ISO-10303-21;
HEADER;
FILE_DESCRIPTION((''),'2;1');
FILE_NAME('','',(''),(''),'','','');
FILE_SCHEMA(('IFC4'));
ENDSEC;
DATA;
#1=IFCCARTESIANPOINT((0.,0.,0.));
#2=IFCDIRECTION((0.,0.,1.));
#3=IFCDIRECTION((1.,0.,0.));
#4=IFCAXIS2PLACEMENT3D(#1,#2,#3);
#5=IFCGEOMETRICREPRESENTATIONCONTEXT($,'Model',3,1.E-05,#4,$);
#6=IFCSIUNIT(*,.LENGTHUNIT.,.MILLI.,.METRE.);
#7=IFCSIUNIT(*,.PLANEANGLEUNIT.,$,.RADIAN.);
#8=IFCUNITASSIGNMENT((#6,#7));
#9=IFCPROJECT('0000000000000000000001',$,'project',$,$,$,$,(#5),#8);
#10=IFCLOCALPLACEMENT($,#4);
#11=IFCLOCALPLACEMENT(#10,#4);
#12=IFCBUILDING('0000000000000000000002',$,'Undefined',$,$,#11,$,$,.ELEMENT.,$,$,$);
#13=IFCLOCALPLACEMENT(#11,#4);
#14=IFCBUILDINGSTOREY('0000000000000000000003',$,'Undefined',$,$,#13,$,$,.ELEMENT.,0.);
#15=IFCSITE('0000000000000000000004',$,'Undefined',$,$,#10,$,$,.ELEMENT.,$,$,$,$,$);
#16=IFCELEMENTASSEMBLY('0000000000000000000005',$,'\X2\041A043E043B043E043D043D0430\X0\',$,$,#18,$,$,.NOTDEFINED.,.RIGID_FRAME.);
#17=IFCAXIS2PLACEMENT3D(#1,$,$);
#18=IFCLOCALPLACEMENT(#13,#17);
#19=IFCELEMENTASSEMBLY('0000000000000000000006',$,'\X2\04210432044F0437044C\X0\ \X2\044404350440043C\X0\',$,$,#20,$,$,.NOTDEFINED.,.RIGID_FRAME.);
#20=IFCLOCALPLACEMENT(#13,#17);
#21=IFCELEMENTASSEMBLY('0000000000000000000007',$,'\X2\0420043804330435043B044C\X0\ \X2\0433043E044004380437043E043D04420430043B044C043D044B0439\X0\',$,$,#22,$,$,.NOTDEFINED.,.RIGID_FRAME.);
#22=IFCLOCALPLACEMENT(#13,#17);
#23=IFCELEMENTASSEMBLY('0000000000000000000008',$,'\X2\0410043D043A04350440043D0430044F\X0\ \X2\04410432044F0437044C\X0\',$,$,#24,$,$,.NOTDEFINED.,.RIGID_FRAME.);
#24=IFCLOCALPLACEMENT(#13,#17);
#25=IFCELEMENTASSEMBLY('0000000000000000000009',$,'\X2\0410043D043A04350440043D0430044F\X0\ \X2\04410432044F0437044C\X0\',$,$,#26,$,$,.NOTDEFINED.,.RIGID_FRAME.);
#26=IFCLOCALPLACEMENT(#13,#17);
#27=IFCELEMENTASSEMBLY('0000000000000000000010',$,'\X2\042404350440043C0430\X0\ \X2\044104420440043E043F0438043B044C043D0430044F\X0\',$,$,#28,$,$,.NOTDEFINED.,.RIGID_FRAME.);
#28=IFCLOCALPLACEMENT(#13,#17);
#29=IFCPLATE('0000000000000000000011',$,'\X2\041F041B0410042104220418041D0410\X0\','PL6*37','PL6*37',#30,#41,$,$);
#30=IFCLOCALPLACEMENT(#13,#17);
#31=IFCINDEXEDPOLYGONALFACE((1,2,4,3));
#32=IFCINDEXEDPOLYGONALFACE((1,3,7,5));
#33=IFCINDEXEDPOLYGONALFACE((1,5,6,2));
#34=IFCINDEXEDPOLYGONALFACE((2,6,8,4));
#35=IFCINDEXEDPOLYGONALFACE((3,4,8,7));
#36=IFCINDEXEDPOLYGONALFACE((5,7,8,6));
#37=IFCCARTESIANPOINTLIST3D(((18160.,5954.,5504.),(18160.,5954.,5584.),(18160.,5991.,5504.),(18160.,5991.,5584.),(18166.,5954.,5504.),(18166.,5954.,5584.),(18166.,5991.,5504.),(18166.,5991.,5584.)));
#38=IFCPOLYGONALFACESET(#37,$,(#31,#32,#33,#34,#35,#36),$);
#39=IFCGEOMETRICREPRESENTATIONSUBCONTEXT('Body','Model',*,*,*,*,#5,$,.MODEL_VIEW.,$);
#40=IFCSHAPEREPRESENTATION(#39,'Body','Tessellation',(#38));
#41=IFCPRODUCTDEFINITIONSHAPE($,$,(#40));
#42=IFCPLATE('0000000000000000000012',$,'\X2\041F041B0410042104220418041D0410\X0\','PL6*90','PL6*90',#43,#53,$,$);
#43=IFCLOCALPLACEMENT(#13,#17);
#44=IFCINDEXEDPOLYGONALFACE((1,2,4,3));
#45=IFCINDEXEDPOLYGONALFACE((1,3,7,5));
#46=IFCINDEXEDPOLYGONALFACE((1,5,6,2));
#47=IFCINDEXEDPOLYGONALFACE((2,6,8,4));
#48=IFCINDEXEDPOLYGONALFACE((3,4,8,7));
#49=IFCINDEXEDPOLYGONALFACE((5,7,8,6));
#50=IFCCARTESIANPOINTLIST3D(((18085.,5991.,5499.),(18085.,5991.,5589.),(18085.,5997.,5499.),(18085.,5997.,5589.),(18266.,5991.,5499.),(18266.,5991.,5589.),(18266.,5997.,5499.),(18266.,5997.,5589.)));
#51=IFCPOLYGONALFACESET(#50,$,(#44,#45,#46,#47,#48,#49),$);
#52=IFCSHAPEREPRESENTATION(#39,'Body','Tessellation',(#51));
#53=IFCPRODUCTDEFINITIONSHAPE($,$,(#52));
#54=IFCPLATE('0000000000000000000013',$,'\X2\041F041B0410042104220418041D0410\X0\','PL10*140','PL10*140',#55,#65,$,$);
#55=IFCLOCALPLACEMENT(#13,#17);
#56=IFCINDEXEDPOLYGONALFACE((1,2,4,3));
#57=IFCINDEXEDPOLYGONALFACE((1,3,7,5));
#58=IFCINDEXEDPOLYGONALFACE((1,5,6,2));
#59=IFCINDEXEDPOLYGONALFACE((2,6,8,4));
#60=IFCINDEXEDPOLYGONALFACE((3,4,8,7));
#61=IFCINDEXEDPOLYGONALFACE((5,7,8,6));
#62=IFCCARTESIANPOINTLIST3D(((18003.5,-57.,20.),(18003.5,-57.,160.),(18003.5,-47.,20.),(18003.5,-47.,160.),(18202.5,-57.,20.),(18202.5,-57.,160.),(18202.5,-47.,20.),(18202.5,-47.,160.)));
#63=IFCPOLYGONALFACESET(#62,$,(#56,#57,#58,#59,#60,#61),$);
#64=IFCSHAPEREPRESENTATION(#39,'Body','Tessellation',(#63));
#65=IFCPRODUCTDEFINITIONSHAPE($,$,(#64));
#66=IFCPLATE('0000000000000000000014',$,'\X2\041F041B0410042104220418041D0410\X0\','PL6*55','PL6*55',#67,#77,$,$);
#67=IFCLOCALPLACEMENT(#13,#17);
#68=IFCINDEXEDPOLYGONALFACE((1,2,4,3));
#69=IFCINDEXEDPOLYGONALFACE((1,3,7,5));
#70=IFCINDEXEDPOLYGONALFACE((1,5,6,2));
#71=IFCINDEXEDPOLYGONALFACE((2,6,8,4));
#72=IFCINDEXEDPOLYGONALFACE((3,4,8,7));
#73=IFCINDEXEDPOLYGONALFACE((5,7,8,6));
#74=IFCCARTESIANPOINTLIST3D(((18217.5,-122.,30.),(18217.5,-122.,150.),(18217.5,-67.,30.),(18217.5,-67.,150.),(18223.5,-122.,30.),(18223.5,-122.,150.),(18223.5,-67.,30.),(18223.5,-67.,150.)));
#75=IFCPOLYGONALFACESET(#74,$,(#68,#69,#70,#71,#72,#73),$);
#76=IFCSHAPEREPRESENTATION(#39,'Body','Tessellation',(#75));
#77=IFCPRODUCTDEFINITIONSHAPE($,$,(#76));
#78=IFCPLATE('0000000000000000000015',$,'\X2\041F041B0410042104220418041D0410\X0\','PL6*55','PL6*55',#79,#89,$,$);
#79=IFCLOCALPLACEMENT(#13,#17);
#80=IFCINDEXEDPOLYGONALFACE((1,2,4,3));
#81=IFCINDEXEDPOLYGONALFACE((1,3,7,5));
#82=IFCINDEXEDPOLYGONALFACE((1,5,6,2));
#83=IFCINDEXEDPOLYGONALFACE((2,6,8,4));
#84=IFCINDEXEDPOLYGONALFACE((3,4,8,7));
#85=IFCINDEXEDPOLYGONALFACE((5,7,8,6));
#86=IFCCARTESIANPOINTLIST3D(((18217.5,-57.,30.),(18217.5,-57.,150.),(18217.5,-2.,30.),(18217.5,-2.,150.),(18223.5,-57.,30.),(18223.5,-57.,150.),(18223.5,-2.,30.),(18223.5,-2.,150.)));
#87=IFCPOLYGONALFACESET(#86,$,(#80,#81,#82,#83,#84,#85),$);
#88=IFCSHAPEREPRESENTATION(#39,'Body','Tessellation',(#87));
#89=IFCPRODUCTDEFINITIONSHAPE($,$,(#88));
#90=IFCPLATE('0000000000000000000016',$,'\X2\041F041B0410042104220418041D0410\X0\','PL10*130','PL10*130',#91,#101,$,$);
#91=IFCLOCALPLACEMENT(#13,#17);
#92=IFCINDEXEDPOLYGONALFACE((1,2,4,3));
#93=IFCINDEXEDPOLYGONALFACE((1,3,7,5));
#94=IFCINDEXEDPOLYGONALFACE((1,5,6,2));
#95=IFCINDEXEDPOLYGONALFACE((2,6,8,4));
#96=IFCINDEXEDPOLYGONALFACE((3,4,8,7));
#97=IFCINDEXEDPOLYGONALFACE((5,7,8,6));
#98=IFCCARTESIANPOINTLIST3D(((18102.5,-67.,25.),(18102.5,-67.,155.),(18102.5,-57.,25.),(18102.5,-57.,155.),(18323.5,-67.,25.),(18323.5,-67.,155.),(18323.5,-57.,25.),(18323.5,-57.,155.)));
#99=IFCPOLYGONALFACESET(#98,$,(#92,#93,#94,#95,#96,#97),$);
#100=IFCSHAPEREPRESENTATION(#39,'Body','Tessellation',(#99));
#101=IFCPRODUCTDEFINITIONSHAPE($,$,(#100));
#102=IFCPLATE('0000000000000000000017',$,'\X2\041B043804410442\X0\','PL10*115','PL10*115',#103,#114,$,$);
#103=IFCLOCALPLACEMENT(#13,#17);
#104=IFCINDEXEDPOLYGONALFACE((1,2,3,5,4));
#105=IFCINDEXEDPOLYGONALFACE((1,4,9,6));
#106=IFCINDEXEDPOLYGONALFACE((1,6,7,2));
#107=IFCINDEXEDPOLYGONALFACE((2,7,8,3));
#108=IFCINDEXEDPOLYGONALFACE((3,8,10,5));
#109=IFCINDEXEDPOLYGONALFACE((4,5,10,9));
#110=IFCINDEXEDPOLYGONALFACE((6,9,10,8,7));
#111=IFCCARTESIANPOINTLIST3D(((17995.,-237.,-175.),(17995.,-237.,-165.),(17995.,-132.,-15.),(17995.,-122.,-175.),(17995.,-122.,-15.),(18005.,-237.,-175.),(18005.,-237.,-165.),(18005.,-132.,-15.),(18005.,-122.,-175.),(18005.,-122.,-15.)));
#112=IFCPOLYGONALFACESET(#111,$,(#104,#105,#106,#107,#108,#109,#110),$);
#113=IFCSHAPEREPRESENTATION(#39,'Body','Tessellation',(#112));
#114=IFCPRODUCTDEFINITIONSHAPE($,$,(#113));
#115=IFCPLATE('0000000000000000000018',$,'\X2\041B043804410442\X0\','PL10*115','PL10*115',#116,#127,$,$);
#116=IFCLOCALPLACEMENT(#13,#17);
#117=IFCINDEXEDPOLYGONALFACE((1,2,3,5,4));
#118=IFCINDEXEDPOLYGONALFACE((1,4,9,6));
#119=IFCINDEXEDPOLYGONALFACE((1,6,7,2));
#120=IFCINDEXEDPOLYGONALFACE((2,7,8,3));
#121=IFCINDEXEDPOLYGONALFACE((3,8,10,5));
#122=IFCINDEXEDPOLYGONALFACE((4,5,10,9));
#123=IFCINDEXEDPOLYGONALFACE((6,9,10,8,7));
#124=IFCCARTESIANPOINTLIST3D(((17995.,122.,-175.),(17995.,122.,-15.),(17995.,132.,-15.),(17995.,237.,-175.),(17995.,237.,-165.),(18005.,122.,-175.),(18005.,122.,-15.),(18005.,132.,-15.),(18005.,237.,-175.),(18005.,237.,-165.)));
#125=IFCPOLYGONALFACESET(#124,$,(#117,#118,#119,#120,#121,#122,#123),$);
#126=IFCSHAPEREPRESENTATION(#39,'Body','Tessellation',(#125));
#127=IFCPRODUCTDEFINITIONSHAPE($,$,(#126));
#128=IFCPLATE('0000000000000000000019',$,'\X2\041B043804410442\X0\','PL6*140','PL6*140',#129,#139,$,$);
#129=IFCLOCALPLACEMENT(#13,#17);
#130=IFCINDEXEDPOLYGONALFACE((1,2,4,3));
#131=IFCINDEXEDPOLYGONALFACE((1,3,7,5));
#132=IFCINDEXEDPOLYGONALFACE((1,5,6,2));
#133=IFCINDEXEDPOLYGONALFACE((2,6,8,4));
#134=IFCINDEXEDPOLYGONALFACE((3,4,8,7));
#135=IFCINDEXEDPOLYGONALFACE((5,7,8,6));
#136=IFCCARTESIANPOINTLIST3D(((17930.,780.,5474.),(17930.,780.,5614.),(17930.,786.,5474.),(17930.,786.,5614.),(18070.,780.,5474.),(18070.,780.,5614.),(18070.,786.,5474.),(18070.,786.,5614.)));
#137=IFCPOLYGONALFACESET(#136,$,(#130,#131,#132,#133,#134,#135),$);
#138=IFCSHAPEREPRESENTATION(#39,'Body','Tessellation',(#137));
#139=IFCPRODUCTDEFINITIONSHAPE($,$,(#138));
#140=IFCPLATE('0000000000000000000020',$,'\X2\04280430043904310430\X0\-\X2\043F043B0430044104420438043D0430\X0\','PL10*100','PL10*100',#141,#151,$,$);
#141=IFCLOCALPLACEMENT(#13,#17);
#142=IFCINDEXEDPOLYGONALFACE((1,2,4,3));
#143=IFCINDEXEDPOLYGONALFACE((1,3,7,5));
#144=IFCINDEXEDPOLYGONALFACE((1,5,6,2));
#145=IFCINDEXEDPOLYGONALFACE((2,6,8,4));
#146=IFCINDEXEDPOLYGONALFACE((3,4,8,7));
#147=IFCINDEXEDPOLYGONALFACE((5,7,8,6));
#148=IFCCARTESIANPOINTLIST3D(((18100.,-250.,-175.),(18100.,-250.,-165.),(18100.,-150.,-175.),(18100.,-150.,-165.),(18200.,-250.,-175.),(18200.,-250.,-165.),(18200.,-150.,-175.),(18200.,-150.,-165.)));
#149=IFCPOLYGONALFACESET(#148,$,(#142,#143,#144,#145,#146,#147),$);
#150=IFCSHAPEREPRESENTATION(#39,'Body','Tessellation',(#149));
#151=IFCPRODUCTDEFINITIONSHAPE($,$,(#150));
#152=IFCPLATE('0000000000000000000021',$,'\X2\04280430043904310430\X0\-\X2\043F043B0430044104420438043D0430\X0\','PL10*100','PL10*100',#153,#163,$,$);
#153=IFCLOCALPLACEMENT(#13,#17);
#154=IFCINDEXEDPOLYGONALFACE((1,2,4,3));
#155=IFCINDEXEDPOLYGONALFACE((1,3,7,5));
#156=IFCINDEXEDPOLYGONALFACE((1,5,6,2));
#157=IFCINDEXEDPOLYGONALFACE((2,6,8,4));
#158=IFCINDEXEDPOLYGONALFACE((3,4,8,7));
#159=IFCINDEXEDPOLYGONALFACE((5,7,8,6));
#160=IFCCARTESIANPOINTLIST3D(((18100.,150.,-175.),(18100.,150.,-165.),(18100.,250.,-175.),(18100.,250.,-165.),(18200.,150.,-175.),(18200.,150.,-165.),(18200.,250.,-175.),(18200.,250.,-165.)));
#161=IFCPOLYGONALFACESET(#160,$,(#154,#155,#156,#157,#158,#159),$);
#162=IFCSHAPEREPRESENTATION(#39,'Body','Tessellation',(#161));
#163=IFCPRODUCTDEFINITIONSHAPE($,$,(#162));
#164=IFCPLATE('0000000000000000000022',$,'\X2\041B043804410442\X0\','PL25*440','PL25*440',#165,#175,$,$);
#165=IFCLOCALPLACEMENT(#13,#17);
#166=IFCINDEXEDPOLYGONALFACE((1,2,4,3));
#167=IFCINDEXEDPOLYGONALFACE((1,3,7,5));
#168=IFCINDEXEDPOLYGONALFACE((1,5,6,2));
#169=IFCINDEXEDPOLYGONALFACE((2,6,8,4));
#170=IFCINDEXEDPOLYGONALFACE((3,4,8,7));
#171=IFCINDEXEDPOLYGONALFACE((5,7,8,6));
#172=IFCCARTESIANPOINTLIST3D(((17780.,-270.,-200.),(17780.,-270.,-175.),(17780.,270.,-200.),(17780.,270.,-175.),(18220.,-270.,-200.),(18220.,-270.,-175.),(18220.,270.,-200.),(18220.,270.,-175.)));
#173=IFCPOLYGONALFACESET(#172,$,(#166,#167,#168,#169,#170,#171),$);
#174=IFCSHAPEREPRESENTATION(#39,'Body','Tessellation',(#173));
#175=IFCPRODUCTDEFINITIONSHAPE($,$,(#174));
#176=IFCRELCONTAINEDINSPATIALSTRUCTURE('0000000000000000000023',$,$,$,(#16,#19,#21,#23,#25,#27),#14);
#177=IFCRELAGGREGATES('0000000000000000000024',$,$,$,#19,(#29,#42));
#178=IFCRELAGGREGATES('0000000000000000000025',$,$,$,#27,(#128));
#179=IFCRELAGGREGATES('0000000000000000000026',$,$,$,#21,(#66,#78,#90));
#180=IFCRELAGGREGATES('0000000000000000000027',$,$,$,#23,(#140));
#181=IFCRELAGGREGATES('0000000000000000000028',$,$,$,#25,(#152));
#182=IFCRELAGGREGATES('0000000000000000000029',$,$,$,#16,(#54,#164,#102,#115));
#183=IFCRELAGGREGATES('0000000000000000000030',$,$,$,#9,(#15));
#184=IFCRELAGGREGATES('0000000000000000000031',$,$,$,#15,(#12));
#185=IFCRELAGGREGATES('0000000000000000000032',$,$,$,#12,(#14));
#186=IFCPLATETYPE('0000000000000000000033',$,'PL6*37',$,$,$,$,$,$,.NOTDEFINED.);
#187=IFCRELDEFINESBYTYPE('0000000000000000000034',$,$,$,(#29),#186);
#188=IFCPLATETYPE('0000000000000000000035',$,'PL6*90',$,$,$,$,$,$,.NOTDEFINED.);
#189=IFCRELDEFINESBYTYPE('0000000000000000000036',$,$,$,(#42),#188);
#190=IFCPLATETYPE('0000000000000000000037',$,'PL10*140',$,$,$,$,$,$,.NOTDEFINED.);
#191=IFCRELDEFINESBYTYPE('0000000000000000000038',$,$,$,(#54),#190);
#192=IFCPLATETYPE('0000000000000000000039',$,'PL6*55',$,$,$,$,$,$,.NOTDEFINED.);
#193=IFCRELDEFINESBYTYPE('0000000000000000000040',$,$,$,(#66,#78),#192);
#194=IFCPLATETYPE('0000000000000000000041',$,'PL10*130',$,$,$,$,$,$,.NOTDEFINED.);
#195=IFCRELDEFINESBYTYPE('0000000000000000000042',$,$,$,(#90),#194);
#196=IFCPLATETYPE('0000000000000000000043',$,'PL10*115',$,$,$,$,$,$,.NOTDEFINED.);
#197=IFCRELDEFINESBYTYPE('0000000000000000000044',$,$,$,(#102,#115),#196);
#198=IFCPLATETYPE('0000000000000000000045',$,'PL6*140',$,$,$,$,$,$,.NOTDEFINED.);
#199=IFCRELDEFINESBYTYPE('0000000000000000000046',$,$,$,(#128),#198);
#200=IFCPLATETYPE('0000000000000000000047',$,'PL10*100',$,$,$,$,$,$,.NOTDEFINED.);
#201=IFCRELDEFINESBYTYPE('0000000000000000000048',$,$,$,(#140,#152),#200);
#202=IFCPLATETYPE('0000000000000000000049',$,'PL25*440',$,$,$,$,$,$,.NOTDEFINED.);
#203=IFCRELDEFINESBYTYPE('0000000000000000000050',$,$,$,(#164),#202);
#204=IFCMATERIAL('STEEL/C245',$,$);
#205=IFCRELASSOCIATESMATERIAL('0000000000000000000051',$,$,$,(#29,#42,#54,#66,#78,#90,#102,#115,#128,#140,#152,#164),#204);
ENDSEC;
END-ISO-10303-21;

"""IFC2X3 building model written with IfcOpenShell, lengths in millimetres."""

from ifc_helpers import new_model, si_unit, frame, origin_with_axes, place, context, subcontext, project, spatial, polyline, outline, extrude, material, type_object, element, aggregate, save


model = new_model("IFC2X3")

# Units and contexts
model_context = context("Model", 3, precision=1e-05, world=origin_with_axes())
body_context = subcontext(model_context, "Body", "Model", "MODEL_VIEW")
ifc_project = project(units=[si_unit("LENGTHUNIT", "METRE", prefix="MILLI"), si_unit("PLANEANGLEUNIT", "RADIAN")], contexts=[model_context])

# Site, building, storey
site_placement = place(None, origin_with_axes())
site = spatial("IfcSite", under=ifc_project, at=site_placement, Name="Undefined", CompositionType="ELEMENT")
building_placement = place(site_placement, origin_with_axes())
building = spatial("IfcBuilding", under=site, at=building_placement, Name="Undefined", CompositionType="ELEMENT")
storey_placement = place(building_placement, origin_with_axes())
storey = spatial("IfcBuildingStorey", under=building, at=storey_placement, Name="Undefined", CompositionType="ELEMENT", Elevation=0.0)

# Element assembly
ifc_material_1 = material(Name="STEEL/C245")
assembly_1_placement = place(storey_placement, origin_with_axes())
assembly_1 = element("IfcElementAssembly", 1, at=assembly_1_placement, inside=storey, Name="Колонна", AssemblyPlace="NOTDEFINED", PredefinedType="RIGID_FRAME")

# Element assemblies
assembly_2_placement = place(storey_placement, origin_with_axes())
assembly_2 = element("IfcElementAssembly", 2, at=assembly_2_placement, inside=storey, Name="Связь ферм", AssemblyPlace="NOTDEFINED", PredefinedType="RIGID_FRAME")
assembly_3_placement = place(storey_placement, origin_with_axes())
assembly_3 = element("IfcElementAssembly", 3, at=assembly_3_placement, inside=storey, Name="Ригель горизонтальный", AssemblyPlace="NOTDEFINED", PredefinedType="RIGID_FRAME")

# Element assemblies
assembly_4_placement = place(storey_placement, origin_with_axes())
assembly_4 = element("IfcElementAssembly", 4, at=assembly_4_placement, inside=storey, Name="Анкерная связь", AssemblyPlace="NOTDEFINED", PredefinedType="RIGID_FRAME")
assembly_5_placement = place(storey_placement, origin_with_axes())
assembly_5 = element("IfcElementAssembly", 5, at=assembly_5_placement, inside=storey, Name="Анкерная связь", AssemblyPlace="NOTDEFINED", PredefinedType="RIGID_FRAME")

# Element assembly
assembly_6_placement = place(storey_placement, origin_with_axes())
assembly_6 = element("IfcElementAssembly", 6, at=assembly_6_placement, inside=storey, Name="Ферма стропильная", AssemblyPlace="NOTDEFINED", PredefinedType="RIGID_FRAME")

# Plates
plate_type_1 = type_object("IfcPlateType", Name="PL6*37", PredefinedType="NOTDEFINED")
plate_1_placement = place(assembly_2_placement, frame((18163.0, 5972.5, 5504.0), z_axis=(-1.0, 0.0, 0.0), x_axis=(0.0, 0.0, 1.0)))
plate_1 = element("IfcPlate", 7, at=plate_1_placement, type_object=plate_type_1, material=ifc_material_1, Name="ПЛАСТИНА", Description="PL6*37", ObjectType="PL6*37", context=body_context, shape_type="SweptSolid", body=[
    extrude(outline(polyline([(0.0, -18.5), (0.0, 18.5), (80.0, 18.5), (80.0, -18.5), (0.0, -18.5)])), frame((0.0, 0.0, -3.0), z_axis=(0.0, 0.0, 1.0), x_axis=(1.0, 0.0, 0.0)), (0.0, 0.0, 1.0), 6.0),
])
plate_type_2 = type_object("IfcPlateType", Name="PL6*90", PredefinedType="NOTDEFINED")
plate_2_placement = place(assembly_2_placement, frame((18085.0, 5994.0, 5544.0), z_axis=(0.0, 1.0, 0.0), x_axis=(1.0, 0.0, 0.0)))
plate_2 = element("IfcPlate", 8, at=plate_2_placement, type_object=plate_type_2, material=ifc_material_1, Name="ПЛАСТИНА", Description="PL6*90", ObjectType="PL6*90", context=body_context, shape_type="SweptSolid", body=[
    extrude(outline(polyline([(0.0, 45.0), (181.0, 45.0), (181.0, -45.0), (0.0, -45.0), (0.0, 45.0)])), frame((0.0, 0.0, -3.0), z_axis=(0.0, 0.0, 1.0), x_axis=(1.0, 0.0, 0.0)), (0.0, 0.0, 1.0), 6.0),
])
aggregate(assembly_2, [plate_1, plate_2])
plate_type_3 = type_object("IfcPlateType", Name="PL10*140", PredefinedType="NOTDEFINED")
plate_3_placement = place(assembly_1_placement, frame((18003.5, -52.0, 20.0), z_axis=(0.0, -1.0, 0.0), x_axis=(1.0, 0.0, 0.0)))
plate_3 = element("IfcPlate", 9, at=plate_3_placement, type_object=plate_type_3, material=ifc_material_1, Name="ПЛАСТИНА", Description="PL10*140", ObjectType="PL10*140", context=body_context, shape_type="SweptSolid", body=[
    extrude(outline(polyline([(0.0, 0.0), (199.0, 0.0), (199.0, 140.0), (0.0, 140.0), (0.0, 0.0)])), frame((0.0, 0.0, -5.0), z_axis=(0.0, 0.0, 1.0), x_axis=(1.0, 0.0, 0.0)), (0.0, 0.0, 1.0), 10.0),
])
plate_type_4 = type_object("IfcPlateType", Name="PL6*55", PredefinedType="NOTDEFINED")
plate_4_placement = place(assembly_3_placement, frame((18220.5, -94.5, 150.0), z_axis=(1.0, 0.0, 0.0), x_axis=(0.0, 0.0, -1.0)))
plate_4 = element("IfcPlate", 10, at=plate_4_placement, type_object=plate_type_4, material=ifc_material_1, Name="ПЛАСТИНА", Description="PL6*55", ObjectType="PL6*55", context=body_context, shape_type="SweptSolid", body=[
    extrude(outline(polyline([(120.0, -27.5), (0.0, -27.5), (0.0, 27.5), (120.0, 27.5), (120.0, -27.5)])), frame((0.0, 0.0, -3.0), z_axis=(0.0, 0.0, 1.0), x_axis=(1.0, 0.0, 0.0)), (0.0, 0.0, 1.0), 6.0),
])
plate_5_placement = place(assembly_3_placement, frame((18220.5, -29.5, 150.0), z_axis=(-1.0, 0.0, 0.0), x_axis=(0.0, 0.0, -1.0)))
plate_5 = element("IfcPlate", 11, at=plate_5_placement, type_object=plate_type_4, material=ifc_material_1, Name="ПЛАСТИНА", Description="PL6*55", ObjectType="PL6*55", context=body_context, shape_type="SweptSolid", body=[
    extrude(outline(polyline([(120.0, 27.5), (120.0, -27.5), (0.0, -27.5), (0.0, 27.5), (120.0, 27.5)])), frame((0.0, 0.0, -3.0), z_axis=(0.0, 0.0, 1.0), x_axis=(1.0, 0.0, 0.0)), (0.0, 0.0, 1.0), 6.0),
])
plate_type_5 = type_object("IfcPlateType", Name="PL10*130", PredefinedType="NOTDEFINED")
plate_6_placement = place(assembly_3_placement, frame((18102.5, -62.0, 90.0), z_axis=(0.0, -1.0, 0.0), x_axis=(1.0, 0.0, 0.0)))
plate_6 = element("IfcPlate", 12, at=plate_6_placement, type_object=plate_type_5, material=ifc_material_1, Name="ПЛАСТИНА", Description="PL10*130", ObjectType="PL10*130", context=body_context, shape_type="SweptSolid", body=[
    extrude(outline(polyline([(0.0, -65.0), (0.0, 65.0), (221.0, 65.0), (221.0, -65.0), (0.0, -65.0)])), frame((0.0, 0.0, -5.0), z_axis=(0.0, 0.0, 1.0), x_axis=(1.0, 0.0, 0.0)), (0.0, 0.0, 1.0), 10.0),
])
plate_type_6 = type_object("IfcPlateType", Name="PL10*115", PredefinedType="NOTDEFINED")
plate_7_placement = place(assembly_1_placement, frame((18000.0, -122.0, -15.0), z_axis=(-1.0, 0.0, 0.0), x_axis=(0.0, 0.0, -1.0)))
plate_7 = element("IfcPlate", 13, at=plate_7_placement, type_object=plate_type_6, material=ifc_material_1, Name="Лист", Description="PL10*115", ObjectType="PL10*115", context=body_context, shape_type="SweptSolid", body=[
    extrude(outline(polyline([(0.0, 0.0), (160.0, 0.0), (160.0, 115.0), (150.0, 115.0), (0.0, 10.0), (0.0, 0.0)])), frame((0.0, 0.0, -5.0), z_axis=(0.0, 0.0, 1.0), x_axis=(1.0, 0.0, 0.0)), (0.0, 0.0, 1.0), 10.0),
])
plate_8_placement = place(assembly_1_placement, frame((18000.0, 122.0, -15.0), z_axis=(1.0, 0.0, 0.0), x_axis=(0.0, 0.0, -1.0)))
plate_8 = element("IfcPlate", 14, at=plate_8_placement, type_object=plate_type_6, material=ifc_material_1, Name="Лист", Description="PL10*115", ObjectType="PL10*115", context=body_context, shape_type="SweptSolid", body=[
    extrude(outline(polyline([(0.0, 0.0), (160.0, 0.0), (160.0, 115.0), (150.0, 115.0), (0.0, 10.0), (0.0, 0.0)])), frame((0.0, 0.0, -5.0), z_axis=(0.0, 0.0, 1.0), x_axis=(1.0, 0.0, 0.0)), (0.0, 0.0, 1.0), 10.0),
])
plate_type_7 = type_object("IfcPlateType", Name="PL6*140", PredefinedType="NOTDEFINED")
plate_9_placement = place(assembly_6_placement, frame((18000.0, 783.0, 5474.0), z_axis=(0.0, 1.0, 0.0), x_axis=(0.0, 0.0, 1.0)))
plate_9 = element("IfcPlate", 15, at=plate_9_placement, type_object=plate_type_7, material=ifc_material_1, Name="Лист", Description="PL6*140", ObjectType="PL6*140", context=body_context, shape_type="SweptSolid", body=[
    extrude(outline(polyline([(0.0, -70.0), (0.0, 70.0), (140.0, 70.0), (140.0, -70.0), (0.0, -70.0)])), frame((0.0, 0.0, -3.0), z_axis=(0.0, 0.0, 1.0), x_axis=(1.0, 0.0, 0.0)), (0.0, 0.0, 1.0), 6.0),
])
aggregate(assembly_6, [plate_9])
plate_type_8 = type_object("IfcPlateType", Name="PL10*100", PredefinedType="NOTDEFINED")
plate_10_placement = place(assembly_4_placement, frame((18200.0, -150.0, -170.0), z_axis=(0.0, 0.0, -1.0), x_axis=(0.0, -1.0, 0.0)))
plate_10 = element("IfcPlate", 16, at=plate_10_placement, type_object=plate_type_8, material=ifc_material_1, Name="Шайба-пластина", Description="PL10*100", ObjectType="PL10*100", context=body_context, shape_type="SweptSolid", body=[
    extrude(outline(polyline([(0.0, 0.0), (100.0, 0.0), (100.0, 100.0), (0.0, 100.0), (0.0, 0.0)])), frame((0.0, 0.0, -5.0), z_axis=(0.0, 0.0, 1.0), x_axis=(1.0, 0.0, 0.0)), (0.0, 0.0, 1.0), 10.0),
])
plate_11_placement = place(assembly_5_placement, frame((18200.0, 250.0, -170.0), z_axis=(0.0, 0.0, -1.0), x_axis=(0.0, -1.0, 0.0)))
plate_11 = element("IfcPlate", 17, at=plate_11_placement, type_object=plate_type_8, material=ifc_material_1, Name="Шайба-пластина", Description="PL10*100", ObjectType="PL10*100", context=body_context, shape_type="SweptSolid", body=[
    extrude(outline(polyline([(0.0, 0.0), (100.0, 0.0), (100.0, 100.0), (0.0, 100.0), (0.0, 0.0)])), frame((0.0, 0.0, -5.0), z_axis=(0.0, 0.0, 1.0), x_axis=(1.0, 0.0, 0.0)), (0.0, 0.0, 1.0), 10.0),
])
plate_type_9 = type_object("IfcPlateType", Name="PL25*440", PredefinedType="NOTDEFINED")
plate_12_placement = place(assembly_1_placement, frame((18000.0, -270.0, -187.5), z_axis=(0.0, 0.0, 1.0), x_axis=(0.0, 1.0, 0.0)))
plate_12 = element("IfcPlate", 18, at=plate_12_placement, type_object=plate_type_9, material=ifc_material_1, Name="Лист", Description="PL25*440", ObjectType="PL25*440", context=body_context, shape_type="SweptSolid", body=[
    extrude(outline(polyline([(0.0, 220.0), (540.0, 220.0), (540.0, -220.0), (0.0, -220.0), (0.0, 220.0)])), frame((0.0, 0.0, -12.5), z_axis=(0.0, 0.0, 1.0), x_axis=(1.0, 0.0, 0.0)), (0.0, 0.0, 1.0), 25.0),
])

aggregate(assembly_3, [plate_4, plate_5, plate_6])
aggregate(assembly_4, [plate_10])
aggregate(assembly_5, [plate_11])
aggregate(assembly_1, [plate_3, plate_12, plate_7, plate_8])

save(model, "model.ifc")
